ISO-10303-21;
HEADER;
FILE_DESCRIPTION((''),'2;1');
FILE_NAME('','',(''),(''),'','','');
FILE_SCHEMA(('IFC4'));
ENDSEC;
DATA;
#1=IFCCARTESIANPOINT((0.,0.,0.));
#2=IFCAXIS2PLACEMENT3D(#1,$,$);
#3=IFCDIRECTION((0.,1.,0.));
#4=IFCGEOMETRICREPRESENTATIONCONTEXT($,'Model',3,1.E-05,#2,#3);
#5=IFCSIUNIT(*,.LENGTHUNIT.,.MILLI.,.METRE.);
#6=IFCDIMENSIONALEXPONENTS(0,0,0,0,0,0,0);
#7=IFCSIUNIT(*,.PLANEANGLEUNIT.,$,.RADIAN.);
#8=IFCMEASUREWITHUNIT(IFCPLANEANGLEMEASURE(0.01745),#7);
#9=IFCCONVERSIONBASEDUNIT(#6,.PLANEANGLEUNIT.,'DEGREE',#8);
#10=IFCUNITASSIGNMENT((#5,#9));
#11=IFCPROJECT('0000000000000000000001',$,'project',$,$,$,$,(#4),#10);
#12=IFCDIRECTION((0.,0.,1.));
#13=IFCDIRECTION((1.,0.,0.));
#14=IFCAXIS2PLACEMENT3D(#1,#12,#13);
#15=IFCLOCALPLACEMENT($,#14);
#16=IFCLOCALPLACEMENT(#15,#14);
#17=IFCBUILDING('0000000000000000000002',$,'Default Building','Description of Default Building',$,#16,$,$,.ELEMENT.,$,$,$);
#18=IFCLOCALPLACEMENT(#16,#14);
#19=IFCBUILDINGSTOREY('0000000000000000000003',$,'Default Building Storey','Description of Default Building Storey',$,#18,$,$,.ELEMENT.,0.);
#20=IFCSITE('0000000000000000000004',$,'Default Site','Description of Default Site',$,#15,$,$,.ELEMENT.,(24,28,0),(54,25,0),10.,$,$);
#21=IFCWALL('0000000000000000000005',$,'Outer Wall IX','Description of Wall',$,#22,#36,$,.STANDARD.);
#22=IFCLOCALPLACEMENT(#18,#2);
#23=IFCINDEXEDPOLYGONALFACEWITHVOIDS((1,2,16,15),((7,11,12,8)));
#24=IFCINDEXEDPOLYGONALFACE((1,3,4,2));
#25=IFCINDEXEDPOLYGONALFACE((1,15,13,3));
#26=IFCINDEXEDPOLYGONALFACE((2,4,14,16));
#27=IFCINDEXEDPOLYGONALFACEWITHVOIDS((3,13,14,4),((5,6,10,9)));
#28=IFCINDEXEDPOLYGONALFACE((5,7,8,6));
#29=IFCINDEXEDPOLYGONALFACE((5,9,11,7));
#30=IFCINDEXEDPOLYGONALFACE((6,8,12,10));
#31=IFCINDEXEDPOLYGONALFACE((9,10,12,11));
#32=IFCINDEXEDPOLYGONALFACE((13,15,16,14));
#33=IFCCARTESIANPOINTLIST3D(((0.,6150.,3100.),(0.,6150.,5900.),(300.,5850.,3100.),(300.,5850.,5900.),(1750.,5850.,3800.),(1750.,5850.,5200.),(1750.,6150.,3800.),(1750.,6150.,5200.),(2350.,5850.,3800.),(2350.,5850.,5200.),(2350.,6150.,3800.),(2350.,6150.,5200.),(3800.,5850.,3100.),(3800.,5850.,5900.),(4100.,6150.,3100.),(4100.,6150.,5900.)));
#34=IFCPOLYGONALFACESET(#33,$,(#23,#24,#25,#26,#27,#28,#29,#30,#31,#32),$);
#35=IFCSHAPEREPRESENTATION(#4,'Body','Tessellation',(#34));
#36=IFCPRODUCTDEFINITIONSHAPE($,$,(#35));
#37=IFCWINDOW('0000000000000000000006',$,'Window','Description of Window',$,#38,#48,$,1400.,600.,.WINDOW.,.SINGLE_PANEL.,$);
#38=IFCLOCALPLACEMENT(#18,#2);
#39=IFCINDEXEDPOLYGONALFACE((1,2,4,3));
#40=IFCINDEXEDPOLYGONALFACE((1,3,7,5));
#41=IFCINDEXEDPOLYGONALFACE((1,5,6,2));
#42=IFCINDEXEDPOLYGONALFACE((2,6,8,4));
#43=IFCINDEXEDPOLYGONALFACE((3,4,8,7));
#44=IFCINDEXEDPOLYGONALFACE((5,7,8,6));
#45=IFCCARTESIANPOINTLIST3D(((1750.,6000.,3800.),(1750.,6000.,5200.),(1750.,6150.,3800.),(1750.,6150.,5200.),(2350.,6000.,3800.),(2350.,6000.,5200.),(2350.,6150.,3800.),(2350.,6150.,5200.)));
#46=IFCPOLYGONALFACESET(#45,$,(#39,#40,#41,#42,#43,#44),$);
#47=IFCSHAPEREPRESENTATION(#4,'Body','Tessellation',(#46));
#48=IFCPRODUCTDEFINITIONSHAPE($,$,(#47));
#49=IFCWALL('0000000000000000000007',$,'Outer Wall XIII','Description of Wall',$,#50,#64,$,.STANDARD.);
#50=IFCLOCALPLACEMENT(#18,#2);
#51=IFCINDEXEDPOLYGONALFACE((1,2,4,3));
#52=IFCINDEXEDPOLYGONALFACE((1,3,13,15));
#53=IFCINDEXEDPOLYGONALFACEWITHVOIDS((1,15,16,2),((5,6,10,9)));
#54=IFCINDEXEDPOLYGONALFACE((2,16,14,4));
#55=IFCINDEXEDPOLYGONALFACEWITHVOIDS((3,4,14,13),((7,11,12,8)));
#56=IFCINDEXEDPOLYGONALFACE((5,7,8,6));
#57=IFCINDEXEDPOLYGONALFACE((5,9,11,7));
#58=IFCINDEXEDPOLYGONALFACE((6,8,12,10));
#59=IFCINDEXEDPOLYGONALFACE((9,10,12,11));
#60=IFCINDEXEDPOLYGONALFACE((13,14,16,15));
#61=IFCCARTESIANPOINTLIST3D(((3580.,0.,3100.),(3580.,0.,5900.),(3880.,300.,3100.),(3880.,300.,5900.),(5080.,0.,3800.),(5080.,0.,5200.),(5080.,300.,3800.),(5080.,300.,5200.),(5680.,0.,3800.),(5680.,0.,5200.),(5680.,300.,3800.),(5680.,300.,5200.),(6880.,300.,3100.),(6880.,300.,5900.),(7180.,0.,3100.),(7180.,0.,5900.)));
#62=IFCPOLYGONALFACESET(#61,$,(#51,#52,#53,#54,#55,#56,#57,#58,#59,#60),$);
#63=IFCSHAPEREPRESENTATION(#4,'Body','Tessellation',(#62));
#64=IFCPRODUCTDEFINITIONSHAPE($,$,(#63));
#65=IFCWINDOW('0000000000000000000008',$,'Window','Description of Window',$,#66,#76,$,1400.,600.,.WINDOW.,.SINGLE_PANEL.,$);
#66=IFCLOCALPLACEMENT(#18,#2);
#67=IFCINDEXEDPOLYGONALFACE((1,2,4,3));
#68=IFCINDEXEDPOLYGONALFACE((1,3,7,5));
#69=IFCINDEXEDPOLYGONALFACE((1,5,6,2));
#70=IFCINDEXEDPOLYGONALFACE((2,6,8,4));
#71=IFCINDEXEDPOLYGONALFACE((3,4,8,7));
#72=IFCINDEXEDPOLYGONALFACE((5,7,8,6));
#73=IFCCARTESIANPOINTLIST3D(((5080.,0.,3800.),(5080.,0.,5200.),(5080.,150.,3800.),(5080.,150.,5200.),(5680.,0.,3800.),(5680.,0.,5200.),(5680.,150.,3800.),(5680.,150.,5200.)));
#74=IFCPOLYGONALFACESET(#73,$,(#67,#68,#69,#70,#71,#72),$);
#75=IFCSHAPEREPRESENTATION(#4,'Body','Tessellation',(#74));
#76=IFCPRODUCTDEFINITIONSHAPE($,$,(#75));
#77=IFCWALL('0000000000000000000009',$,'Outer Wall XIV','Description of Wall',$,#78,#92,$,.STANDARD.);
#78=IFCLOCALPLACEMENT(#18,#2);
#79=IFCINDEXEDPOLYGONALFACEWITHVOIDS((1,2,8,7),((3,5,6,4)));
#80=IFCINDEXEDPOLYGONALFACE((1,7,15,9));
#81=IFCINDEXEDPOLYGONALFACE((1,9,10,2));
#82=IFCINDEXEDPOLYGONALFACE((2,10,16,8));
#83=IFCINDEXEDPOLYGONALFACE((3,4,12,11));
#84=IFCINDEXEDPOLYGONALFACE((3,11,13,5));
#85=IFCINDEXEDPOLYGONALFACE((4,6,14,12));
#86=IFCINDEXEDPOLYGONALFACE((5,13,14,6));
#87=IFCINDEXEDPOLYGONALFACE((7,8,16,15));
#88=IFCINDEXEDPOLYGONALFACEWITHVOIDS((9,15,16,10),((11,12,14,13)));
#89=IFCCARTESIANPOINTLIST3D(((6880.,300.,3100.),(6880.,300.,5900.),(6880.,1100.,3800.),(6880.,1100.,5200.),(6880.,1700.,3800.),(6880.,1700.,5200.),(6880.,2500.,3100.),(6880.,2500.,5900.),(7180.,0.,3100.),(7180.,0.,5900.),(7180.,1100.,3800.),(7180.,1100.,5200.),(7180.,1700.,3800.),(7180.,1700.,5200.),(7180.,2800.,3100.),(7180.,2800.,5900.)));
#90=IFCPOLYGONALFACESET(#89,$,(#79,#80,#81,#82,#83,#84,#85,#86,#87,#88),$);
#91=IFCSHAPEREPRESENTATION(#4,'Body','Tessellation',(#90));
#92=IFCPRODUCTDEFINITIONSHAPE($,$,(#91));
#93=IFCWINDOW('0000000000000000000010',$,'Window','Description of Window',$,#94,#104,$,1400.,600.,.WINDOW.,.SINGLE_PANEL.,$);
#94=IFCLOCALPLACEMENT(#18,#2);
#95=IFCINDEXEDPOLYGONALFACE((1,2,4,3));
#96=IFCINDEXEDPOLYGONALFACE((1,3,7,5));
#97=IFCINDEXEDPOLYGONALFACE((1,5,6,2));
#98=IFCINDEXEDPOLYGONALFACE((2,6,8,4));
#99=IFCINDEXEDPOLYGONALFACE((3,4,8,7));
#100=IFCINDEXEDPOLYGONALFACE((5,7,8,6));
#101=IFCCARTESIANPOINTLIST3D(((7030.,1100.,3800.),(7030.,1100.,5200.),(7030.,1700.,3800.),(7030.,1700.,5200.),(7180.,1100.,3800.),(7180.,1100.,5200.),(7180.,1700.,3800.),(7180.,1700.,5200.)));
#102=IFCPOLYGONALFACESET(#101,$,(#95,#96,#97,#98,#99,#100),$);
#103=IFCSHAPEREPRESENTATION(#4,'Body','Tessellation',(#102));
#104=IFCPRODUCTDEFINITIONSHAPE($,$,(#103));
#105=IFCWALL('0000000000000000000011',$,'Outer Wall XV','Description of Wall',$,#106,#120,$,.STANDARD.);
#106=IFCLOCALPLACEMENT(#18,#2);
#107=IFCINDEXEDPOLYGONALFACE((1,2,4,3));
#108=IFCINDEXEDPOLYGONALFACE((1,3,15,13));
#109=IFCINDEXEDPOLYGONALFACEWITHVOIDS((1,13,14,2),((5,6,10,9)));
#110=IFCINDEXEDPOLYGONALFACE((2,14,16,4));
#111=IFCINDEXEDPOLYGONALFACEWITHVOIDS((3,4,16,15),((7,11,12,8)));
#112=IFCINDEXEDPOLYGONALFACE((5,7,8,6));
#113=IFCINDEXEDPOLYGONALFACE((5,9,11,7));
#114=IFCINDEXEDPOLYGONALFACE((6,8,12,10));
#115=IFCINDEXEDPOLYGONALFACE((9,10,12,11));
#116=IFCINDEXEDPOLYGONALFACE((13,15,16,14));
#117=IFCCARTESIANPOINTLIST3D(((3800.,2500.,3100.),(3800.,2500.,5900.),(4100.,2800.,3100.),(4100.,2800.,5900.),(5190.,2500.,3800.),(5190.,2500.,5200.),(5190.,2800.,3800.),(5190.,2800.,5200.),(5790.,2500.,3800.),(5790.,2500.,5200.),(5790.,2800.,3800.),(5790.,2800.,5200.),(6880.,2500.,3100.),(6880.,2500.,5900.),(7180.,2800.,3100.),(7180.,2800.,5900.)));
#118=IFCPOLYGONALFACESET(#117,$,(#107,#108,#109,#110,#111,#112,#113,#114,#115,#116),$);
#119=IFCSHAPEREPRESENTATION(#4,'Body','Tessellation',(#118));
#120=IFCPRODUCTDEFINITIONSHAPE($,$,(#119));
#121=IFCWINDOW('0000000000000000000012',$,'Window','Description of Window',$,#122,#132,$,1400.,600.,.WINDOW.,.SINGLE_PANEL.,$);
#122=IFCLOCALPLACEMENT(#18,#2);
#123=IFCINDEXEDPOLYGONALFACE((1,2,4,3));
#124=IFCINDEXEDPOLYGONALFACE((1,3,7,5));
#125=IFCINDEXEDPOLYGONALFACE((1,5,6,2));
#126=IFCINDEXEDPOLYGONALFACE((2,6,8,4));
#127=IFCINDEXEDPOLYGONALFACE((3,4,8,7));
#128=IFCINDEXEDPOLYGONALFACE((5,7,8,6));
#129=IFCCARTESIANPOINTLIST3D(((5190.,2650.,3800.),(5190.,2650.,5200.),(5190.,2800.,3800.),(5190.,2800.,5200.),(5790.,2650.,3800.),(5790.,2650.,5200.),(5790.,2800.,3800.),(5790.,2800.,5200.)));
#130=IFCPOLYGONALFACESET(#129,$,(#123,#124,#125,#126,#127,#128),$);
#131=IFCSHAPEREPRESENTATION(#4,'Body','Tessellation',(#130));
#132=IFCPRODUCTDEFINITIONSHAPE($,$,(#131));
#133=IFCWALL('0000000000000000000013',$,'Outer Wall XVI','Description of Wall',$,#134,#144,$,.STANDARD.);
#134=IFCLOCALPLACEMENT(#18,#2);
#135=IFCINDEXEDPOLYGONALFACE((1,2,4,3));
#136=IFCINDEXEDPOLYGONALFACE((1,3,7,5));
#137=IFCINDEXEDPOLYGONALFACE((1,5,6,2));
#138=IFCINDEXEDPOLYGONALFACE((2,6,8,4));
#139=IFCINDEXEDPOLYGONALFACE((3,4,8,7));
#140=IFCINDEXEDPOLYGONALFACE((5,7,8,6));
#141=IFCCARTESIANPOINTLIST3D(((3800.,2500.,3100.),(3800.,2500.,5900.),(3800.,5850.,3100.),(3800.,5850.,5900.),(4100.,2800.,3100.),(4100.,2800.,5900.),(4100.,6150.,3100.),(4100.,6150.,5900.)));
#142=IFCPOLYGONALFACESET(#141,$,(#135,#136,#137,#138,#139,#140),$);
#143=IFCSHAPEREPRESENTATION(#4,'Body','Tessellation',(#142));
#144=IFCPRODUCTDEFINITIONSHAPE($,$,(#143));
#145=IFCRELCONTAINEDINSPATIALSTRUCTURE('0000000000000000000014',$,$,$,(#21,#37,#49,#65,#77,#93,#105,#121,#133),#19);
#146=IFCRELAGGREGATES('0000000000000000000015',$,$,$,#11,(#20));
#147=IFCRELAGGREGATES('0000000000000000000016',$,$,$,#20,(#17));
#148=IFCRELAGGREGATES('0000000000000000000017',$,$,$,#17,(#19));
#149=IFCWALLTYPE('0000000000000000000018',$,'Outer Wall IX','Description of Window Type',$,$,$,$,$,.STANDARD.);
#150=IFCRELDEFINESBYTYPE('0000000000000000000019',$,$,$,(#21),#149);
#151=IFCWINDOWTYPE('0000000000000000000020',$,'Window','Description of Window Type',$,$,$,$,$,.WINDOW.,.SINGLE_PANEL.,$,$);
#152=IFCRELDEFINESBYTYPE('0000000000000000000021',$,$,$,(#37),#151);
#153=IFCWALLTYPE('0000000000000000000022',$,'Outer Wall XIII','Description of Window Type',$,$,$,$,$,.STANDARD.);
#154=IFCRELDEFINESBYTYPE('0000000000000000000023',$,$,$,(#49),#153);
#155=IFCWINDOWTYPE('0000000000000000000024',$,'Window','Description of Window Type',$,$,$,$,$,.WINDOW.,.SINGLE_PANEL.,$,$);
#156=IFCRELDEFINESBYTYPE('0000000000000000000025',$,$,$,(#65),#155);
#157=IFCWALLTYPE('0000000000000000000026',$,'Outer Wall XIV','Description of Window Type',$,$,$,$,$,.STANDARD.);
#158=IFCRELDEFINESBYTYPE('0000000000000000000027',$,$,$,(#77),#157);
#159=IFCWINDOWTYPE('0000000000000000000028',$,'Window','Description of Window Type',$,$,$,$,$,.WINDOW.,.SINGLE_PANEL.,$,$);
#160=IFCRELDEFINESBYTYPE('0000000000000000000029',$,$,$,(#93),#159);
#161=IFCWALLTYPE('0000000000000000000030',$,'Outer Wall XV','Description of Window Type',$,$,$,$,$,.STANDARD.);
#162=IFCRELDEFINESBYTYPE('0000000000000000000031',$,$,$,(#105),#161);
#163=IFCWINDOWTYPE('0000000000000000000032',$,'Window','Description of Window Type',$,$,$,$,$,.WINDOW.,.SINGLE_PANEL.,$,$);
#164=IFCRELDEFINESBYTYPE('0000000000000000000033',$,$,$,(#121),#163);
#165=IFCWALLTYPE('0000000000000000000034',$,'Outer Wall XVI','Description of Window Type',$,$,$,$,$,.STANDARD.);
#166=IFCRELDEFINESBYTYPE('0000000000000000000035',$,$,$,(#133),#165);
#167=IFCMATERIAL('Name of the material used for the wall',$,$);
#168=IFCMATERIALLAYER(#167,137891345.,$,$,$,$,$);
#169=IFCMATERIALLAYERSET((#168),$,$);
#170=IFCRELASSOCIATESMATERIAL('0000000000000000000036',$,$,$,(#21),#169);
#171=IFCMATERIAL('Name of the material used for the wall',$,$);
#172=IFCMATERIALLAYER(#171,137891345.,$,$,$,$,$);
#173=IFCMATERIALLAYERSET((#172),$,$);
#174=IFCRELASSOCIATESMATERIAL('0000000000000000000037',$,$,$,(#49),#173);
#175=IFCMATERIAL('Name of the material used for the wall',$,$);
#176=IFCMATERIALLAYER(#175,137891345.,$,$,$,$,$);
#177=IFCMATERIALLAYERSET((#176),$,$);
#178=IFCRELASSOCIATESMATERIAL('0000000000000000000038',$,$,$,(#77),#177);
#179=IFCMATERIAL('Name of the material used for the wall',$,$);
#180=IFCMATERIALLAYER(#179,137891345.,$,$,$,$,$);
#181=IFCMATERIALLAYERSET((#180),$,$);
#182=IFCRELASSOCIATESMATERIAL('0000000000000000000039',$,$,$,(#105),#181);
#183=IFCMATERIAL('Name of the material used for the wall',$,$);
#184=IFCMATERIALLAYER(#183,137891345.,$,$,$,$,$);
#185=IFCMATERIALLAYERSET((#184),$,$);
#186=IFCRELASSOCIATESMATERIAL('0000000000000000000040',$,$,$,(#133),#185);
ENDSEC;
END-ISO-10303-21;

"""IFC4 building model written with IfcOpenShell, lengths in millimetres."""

from ifc_helpers import new_model, entity, si_unit, converted_unit, direction, frame, origin, origin_with_axes, place, context, project, spatial, polyline, outline, extrude, material, layer, layer_set, layer_usage, type_object, element, fill, save


model = new_model("IFC4")

# Units and contexts
model_context = context("Model", 3, precision=1e-05, world=origin(), true_north=direction((0.0, 1.0, 0.0)))
ifc_project = project(units=[si_unit("LENGTHUNIT", "METRE", prefix="MILLI"), converted_unit("PLANEANGLEUNIT", "DEGREE", entity("IfcPlaneAngleMeasure", 0.01745), si_unit("PLANEANGLEUNIT", "RADIAN"), dimensions=[0, 0, 0, 0, 0, 0, 0])], contexts=[model_context])

# Site, building, storey
site_placement = place(None, origin_with_axes())
site = spatial("IfcSite", under=ifc_project, at=site_placement, Name="Default Site", Description="Description of Default Site", CompositionType="ELEMENT", RefLatitude=(24, 28, 0), RefLongitude=(54, 25, 0), RefElevation=10.0)
building_placement = place(site_placement, origin_with_axes())
building = spatial("IfcBuilding", under=site, at=building_placement, Name="Default Building", Description="Description of Default Building", CompositionType="ELEMENT")
storey_placement = place(building_placement, origin_with_axes())
storey = spatial("IfcBuildingStorey", under=building, at=storey_placement, Name="Default Building Storey", Description="Description of Default Building Storey", CompositionType="ELEMENT", Elevation=0.0)

# Walls, openings, windows
ifc_material_1 = material(Name="Name of the material used for the wall")
ifc_layer_1 = layer(ifc_material_1, 137891345.0)
ifc_layer_set_1 = layer_set([ifc_layer_1])
ifc_layer_usage_1 = layer_usage(ifc_layer_set_1, "AXIS2", "POSITIVE", -68945672.5)
wall_type_1 = type_object("IfcWallType", Name="Outer Wall IX", Description="Description of Window Type", PredefinedType="STANDARD")
wall_1_placement = place(storey_placement, frame((3950.0, 6000.0, 3100.0), z_axis=(0.0, 0.0, 1.0), x_axis=(-1.0, 0.0, 0.0)))
wall_1 = element("IfcWall", 1, at=wall_1_placement, inside=storey, type_object=wall_type_1, material=ifc_layer_usage_1, Name="Outer Wall IX", Description="Description of Wall", PredefinedType="STANDARD", context=model_context, shape_type="SweptSolid", body=[
    extrude(outline(polyline([(-150.0, -150.0), (150.0, 150.0), (3650.0, 150.0), (3950.0, -150.0), (-150.0, -150.0)])), origin_with_axes(), (0.0, 0.0, 1.0), 2800.0),
])
opening_1_placement = place(wall_1_placement, frame((1600.0, -150.0, 700.0), z_axis=(0.0, 0.0, 1.0), x_axis=(1.0, 0.0, 0.0)))
opening_1 = element("IfcOpeningElement", 2, at=opening_1_placement, cuts=wall_1, context=model_context, shape_type="SweptSolid", body=[
    extrude(outline(polyline([(0.0, 0.0), (0.0, 300.0), (600.0, 300.0), (600.0, 0.0), (0.0, 0.0)])), origin_with_axes(), (0.0, 0.0, 1.0), 1400.0),
])
window_type_1 = type_object("IfcWindowType", Name="Window", Description="Description of Window Type", PartitioningType="SINGLE_PANEL", PredefinedType="WINDOW")
window_1_placement = place(opening_1_placement, origin_with_axes())
window_1 = element("IfcWindow", 3, at=window_1_placement, inside=storey, type_object=window_type_1, Name="Window", Description="Description of Window", OverallHeight=1400.0, OverallWidth=600.0, PartitioningType="SINGLE_PANEL", PredefinedType="WINDOW", context=model_context, shape_type="SweptSolid", body=[
    extrude(outline(polyline([(0.0, 0.0), (0.0, 150.0), (600.0, 150.0), (600.0, 0.0), (0.0, 0.0)])), origin_with_axes(), (0.0, 0.0, 1.0), 1400.0),
])
fill(opening_1, window_1)
ifc_material_2 = material(Name="Name of the material used for the wall")
ifc_layer_2 = layer(ifc_material_2, 137891345.0)
ifc_layer_set_2 = layer_set([ifc_layer_2])
ifc_layer_usage_2 = layer_usage(ifc_layer_set_2, "AXIS2", "POSITIVE", -68945672.5)
wall_type_2 = type_object("IfcWallType", Name="Outer Wall XIII", Description="Description of Window Type", PredefinedType="STANDARD")
wall_2_placement = place(storey_placement, frame((3730.0, 150.0, 3100.0), z_axis=(0.0, 0.0, 1.0), x_axis=(1.0, 0.0, 0.0)))
wall_2 = element("IfcWall", 4, at=wall_2_placement, inside=storey, type_object=wall_type_2, material=ifc_layer_usage_2, Name="Outer Wall XIII", Description="Description of Wall", PredefinedType="STANDARD", context=model_context, shape_type="SweptSolid", body=[
    extrude(outline(polyline([(-150.0, -150.0), (150.0, 150.0), (3150.0, 150.0), (3450.0, -150.0), (-150.0, -150.0)])), origin_with_axes(), (0.0, 0.0, 1.0), 2800.0),
])
opening_2_placement = place(wall_2_placement, frame((1350.0, -150.0, 700.0), z_axis=(0.0, 0.0, 1.0), x_axis=(1.0, 0.0, 0.0)))
opening_2 = element("IfcOpeningElement", 5, at=opening_2_placement, cuts=wall_2, context=model_context, shape_type="SweptSolid", body=[
    extrude(outline(polyline([(0.0, 0.0), (0.0, 300.0), (600.0, 300.0), (600.0, 0.0), (0.0, 0.0)])), origin_with_axes(), (0.0, 0.0, 1.0), 1400.0),
])
window_type_2 = type_object("IfcWindowType", Name="Window", Description="Description of Window Type", PartitioningType="SINGLE_PANEL", PredefinedType="WINDOW")
window_2_placement = place(opening_2_placement, origin_with_axes())
window_2 = element("IfcWindow", 6, at=window_2_placement, inside=storey, type_object=window_type_2, Name="Window", Description="Description of Window", OverallHeight=1400.0, OverallWidth=600.0, PartitioningType="SINGLE_PANEL", PredefinedType="WINDOW", context=model_context, shape_type="SweptSolid", body=[
    extrude(outline(polyline([(0.0, 0.0), (0.0, 150.0), (600.0, 150.0), (600.0, 0.0), (0.0, 0.0)])), origin_with_axes(), (0.0, 0.0, 1.0), 1400.0),
])
fill(opening_2, window_2)
ifc_material_3 = material(Name="Name of the material used for the wall")
ifc_layer_3 = layer(ifc_material_3, 137891345.0)
ifc_layer_set_3 = layer_set([ifc_layer_3])
ifc_layer_usage_3 = layer_usage(ifc_layer_set_3, "AXIS2", "POSITIVE", -68945672.5)
wall_type_3 = type_object("IfcWallType", Name="Outer Wall XIV", Description="Description of Window Type", PredefinedType="STANDARD")
wall_3_placement = place(storey_placement, frame((7030.0, 150.0, 3100.0), z_axis=(0.0, 0.0, 1.0), x_axis=(0.0, 1.0, 0.0)))
wall_3 = element("IfcWall", 7, at=wall_3_placement, inside=storey, type_object=wall_type_3, material=ifc_layer_usage_3, Name="Outer Wall XIV", Description="Description of Wall", PredefinedType="STANDARD", context=model_context, shape_type="SweptSolid", body=[
    extrude(outline(polyline([(-150.0, -150.0), (150.0, 150.0), (2350.0, 150.0), (2650.0, -150.0), (-150.0, -150.0)])), origin_with_axes(), (0.0, 0.0, 1.0), 2800.0),
])
opening_3_placement = place(wall_3_placement, frame((950.0, -150.0, 700.0), z_axis=(0.0, 0.0, 1.0), x_axis=(1.0, 0.0, 0.0)))
opening_3 = element("IfcOpeningElement", 8, at=opening_3_placement, cuts=wall_3, context=model_context, shape_type="SweptSolid", body=[
    extrude(outline(polyline([(0.0, 0.0), (0.0, 300.0), (600.0, 300.0), (600.0, 0.0), (0.0, 0.0)])), origin_with_axes(), (0.0, 0.0, 1.0), 1400.0),
])
window_type_3 = type_object("IfcWindowType", Name="Window", Description="Description of Window Type", PartitioningType="SINGLE_PANEL", PredefinedType="WINDOW")
window_3_placement = place(opening_3_placement, origin_with_axes())
window_3 = element("IfcWindow", 9, at=window_3_placement, inside=storey, type_object=window_type_3, Name="Window", Description="Description of Window", OverallHeight=1400.0, OverallWidth=600.0, PartitioningType="SINGLE_PANEL", PredefinedType="WINDOW", context=model_context, shape_type="SweptSolid", body=[
    extrude(outline(polyline([(0.0, 0.0), (0.0, 150.0), (600.0, 150.0), (600.0, 0.0), (0.0, 0.0)])), origin_with_axes(), (0.0, 0.0, 1.0), 1400.0),
])
fill(opening_3, window_3)
ifc_material_4 = material(Name="Name of the material used for the wall")
ifc_layer_4 = layer(ifc_material_4, 137891345.0)
ifc_layer_set_4 = layer_set([ifc_layer_4])
ifc_layer_usage_4 = layer_usage(ifc_layer_set_4, "AXIS2", "POSITIVE", -68945672.5)
wall_type_4 = type_object("IfcWallType", Name="Outer Wall XV", Description="Description of Window Type", PredefinedType="STANDARD")
wall_4_placement = place(storey_placement, frame((7030.0, 2650.0, 3100.0), z_axis=(0.0, 0.0, 1.0), x_axis=(-1.0, 0.0, 0.0)))
wall_4 = element("IfcWall", 10, at=wall_4_placement, inside=storey, type_object=wall_type_4, material=ifc_layer_usage_4, Name="Outer Wall XV", Description="Description of Wall", PredefinedType="STANDARD", context=model_context, shape_type="SweptSolid", body=[
    extrude(outline(polyline([(-150.0, -150.0), (150.0, 150.0), (3230.0, 150.0), (2930.0, -150.0), (-150.0, -150.0)])), origin_with_axes(), (0.0, 0.0, 1.0), 2800.0),
])
opening_4_placement = place(wall_4_placement, frame((1240.0, -150.0, 700.0), z_axis=(0.0, 0.0, 1.0), x_axis=(1.0, 0.0, 0.0)))
opening_4 = element("IfcOpeningElement", 11, at=opening_4_placement, cuts=wall_4, context=model_context, shape_type="SweptSolid", body=[
    extrude(outline(polyline([(0.0, 0.0), (0.0, 300.0), (600.0, 300.0), (600.0, 0.0), (0.0, 0.0)])), origin_with_axes(), (0.0, 0.0, 1.0), 1400.0),
])
window_type_4 = type_object("IfcWindowType", Name="Window", Description="Description of Window Type", PartitioningType="SINGLE_PANEL", PredefinedType="WINDOW")
window_4_placement = place(opening_4_placement, origin_with_axes())
window_4 = element("IfcWindow", 12, at=window_4_placement, inside=storey, type_object=window_type_4, Name="Window", Description="Description of Window", OverallHeight=1400.0, OverallWidth=600.0, PartitioningType="SINGLE_PANEL", PredefinedType="WINDOW", context=model_context, shape_type="SweptSolid", body=[
    extrude(outline(polyline([(0.0, 0.0), (0.0, 150.0), (600.0, 150.0), (600.0, 0.0), (0.0, 0.0)])), origin_with_axes(), (0.0, 0.0, 1.0), 1400.0),
])
fill(opening_4, window_4)

# Wall
ifc_material_5 = material(Name="Name of the material used for the wall")
ifc_layer_5 = layer(ifc_material_5, 137891345.0)
ifc_layer_set_5 = layer_set([ifc_layer_5])
ifc_layer_usage_5 = layer_usage(ifc_layer_set_5, "AXIS2", "POSITIVE", -68945672.5)
wall_type_5 = type_object("IfcWallType", Name="Outer Wall XVI", Description="Description of Window Type", PredefinedType="STANDARD")
wall_5_placement = place(storey_placement, frame((3950.0, 2650.0, 3100.0), z_axis=(0.0, 0.0, 1.0), x_axis=(0.0, 1.0, 0.0)))
element("IfcWall", 13, at=wall_5_placement, inside=storey, type_object=wall_type_5, material=ifc_layer_usage_5, Name="Outer Wall XVI", Description="Description of Wall", PredefinedType="STANDARD", context=model_context, shape_type="SweptSolid", body=[
    extrude(outline(polyline([(150.0, -150.0), (-150.0, 150.0), (3200.0, 150.0), (3500.0, -150.0), (150.0, -150.0)])), origin_with_axes(), (0.0, 0.0, 1.0), 2800.0),
])

save(model, "model.ifc")
